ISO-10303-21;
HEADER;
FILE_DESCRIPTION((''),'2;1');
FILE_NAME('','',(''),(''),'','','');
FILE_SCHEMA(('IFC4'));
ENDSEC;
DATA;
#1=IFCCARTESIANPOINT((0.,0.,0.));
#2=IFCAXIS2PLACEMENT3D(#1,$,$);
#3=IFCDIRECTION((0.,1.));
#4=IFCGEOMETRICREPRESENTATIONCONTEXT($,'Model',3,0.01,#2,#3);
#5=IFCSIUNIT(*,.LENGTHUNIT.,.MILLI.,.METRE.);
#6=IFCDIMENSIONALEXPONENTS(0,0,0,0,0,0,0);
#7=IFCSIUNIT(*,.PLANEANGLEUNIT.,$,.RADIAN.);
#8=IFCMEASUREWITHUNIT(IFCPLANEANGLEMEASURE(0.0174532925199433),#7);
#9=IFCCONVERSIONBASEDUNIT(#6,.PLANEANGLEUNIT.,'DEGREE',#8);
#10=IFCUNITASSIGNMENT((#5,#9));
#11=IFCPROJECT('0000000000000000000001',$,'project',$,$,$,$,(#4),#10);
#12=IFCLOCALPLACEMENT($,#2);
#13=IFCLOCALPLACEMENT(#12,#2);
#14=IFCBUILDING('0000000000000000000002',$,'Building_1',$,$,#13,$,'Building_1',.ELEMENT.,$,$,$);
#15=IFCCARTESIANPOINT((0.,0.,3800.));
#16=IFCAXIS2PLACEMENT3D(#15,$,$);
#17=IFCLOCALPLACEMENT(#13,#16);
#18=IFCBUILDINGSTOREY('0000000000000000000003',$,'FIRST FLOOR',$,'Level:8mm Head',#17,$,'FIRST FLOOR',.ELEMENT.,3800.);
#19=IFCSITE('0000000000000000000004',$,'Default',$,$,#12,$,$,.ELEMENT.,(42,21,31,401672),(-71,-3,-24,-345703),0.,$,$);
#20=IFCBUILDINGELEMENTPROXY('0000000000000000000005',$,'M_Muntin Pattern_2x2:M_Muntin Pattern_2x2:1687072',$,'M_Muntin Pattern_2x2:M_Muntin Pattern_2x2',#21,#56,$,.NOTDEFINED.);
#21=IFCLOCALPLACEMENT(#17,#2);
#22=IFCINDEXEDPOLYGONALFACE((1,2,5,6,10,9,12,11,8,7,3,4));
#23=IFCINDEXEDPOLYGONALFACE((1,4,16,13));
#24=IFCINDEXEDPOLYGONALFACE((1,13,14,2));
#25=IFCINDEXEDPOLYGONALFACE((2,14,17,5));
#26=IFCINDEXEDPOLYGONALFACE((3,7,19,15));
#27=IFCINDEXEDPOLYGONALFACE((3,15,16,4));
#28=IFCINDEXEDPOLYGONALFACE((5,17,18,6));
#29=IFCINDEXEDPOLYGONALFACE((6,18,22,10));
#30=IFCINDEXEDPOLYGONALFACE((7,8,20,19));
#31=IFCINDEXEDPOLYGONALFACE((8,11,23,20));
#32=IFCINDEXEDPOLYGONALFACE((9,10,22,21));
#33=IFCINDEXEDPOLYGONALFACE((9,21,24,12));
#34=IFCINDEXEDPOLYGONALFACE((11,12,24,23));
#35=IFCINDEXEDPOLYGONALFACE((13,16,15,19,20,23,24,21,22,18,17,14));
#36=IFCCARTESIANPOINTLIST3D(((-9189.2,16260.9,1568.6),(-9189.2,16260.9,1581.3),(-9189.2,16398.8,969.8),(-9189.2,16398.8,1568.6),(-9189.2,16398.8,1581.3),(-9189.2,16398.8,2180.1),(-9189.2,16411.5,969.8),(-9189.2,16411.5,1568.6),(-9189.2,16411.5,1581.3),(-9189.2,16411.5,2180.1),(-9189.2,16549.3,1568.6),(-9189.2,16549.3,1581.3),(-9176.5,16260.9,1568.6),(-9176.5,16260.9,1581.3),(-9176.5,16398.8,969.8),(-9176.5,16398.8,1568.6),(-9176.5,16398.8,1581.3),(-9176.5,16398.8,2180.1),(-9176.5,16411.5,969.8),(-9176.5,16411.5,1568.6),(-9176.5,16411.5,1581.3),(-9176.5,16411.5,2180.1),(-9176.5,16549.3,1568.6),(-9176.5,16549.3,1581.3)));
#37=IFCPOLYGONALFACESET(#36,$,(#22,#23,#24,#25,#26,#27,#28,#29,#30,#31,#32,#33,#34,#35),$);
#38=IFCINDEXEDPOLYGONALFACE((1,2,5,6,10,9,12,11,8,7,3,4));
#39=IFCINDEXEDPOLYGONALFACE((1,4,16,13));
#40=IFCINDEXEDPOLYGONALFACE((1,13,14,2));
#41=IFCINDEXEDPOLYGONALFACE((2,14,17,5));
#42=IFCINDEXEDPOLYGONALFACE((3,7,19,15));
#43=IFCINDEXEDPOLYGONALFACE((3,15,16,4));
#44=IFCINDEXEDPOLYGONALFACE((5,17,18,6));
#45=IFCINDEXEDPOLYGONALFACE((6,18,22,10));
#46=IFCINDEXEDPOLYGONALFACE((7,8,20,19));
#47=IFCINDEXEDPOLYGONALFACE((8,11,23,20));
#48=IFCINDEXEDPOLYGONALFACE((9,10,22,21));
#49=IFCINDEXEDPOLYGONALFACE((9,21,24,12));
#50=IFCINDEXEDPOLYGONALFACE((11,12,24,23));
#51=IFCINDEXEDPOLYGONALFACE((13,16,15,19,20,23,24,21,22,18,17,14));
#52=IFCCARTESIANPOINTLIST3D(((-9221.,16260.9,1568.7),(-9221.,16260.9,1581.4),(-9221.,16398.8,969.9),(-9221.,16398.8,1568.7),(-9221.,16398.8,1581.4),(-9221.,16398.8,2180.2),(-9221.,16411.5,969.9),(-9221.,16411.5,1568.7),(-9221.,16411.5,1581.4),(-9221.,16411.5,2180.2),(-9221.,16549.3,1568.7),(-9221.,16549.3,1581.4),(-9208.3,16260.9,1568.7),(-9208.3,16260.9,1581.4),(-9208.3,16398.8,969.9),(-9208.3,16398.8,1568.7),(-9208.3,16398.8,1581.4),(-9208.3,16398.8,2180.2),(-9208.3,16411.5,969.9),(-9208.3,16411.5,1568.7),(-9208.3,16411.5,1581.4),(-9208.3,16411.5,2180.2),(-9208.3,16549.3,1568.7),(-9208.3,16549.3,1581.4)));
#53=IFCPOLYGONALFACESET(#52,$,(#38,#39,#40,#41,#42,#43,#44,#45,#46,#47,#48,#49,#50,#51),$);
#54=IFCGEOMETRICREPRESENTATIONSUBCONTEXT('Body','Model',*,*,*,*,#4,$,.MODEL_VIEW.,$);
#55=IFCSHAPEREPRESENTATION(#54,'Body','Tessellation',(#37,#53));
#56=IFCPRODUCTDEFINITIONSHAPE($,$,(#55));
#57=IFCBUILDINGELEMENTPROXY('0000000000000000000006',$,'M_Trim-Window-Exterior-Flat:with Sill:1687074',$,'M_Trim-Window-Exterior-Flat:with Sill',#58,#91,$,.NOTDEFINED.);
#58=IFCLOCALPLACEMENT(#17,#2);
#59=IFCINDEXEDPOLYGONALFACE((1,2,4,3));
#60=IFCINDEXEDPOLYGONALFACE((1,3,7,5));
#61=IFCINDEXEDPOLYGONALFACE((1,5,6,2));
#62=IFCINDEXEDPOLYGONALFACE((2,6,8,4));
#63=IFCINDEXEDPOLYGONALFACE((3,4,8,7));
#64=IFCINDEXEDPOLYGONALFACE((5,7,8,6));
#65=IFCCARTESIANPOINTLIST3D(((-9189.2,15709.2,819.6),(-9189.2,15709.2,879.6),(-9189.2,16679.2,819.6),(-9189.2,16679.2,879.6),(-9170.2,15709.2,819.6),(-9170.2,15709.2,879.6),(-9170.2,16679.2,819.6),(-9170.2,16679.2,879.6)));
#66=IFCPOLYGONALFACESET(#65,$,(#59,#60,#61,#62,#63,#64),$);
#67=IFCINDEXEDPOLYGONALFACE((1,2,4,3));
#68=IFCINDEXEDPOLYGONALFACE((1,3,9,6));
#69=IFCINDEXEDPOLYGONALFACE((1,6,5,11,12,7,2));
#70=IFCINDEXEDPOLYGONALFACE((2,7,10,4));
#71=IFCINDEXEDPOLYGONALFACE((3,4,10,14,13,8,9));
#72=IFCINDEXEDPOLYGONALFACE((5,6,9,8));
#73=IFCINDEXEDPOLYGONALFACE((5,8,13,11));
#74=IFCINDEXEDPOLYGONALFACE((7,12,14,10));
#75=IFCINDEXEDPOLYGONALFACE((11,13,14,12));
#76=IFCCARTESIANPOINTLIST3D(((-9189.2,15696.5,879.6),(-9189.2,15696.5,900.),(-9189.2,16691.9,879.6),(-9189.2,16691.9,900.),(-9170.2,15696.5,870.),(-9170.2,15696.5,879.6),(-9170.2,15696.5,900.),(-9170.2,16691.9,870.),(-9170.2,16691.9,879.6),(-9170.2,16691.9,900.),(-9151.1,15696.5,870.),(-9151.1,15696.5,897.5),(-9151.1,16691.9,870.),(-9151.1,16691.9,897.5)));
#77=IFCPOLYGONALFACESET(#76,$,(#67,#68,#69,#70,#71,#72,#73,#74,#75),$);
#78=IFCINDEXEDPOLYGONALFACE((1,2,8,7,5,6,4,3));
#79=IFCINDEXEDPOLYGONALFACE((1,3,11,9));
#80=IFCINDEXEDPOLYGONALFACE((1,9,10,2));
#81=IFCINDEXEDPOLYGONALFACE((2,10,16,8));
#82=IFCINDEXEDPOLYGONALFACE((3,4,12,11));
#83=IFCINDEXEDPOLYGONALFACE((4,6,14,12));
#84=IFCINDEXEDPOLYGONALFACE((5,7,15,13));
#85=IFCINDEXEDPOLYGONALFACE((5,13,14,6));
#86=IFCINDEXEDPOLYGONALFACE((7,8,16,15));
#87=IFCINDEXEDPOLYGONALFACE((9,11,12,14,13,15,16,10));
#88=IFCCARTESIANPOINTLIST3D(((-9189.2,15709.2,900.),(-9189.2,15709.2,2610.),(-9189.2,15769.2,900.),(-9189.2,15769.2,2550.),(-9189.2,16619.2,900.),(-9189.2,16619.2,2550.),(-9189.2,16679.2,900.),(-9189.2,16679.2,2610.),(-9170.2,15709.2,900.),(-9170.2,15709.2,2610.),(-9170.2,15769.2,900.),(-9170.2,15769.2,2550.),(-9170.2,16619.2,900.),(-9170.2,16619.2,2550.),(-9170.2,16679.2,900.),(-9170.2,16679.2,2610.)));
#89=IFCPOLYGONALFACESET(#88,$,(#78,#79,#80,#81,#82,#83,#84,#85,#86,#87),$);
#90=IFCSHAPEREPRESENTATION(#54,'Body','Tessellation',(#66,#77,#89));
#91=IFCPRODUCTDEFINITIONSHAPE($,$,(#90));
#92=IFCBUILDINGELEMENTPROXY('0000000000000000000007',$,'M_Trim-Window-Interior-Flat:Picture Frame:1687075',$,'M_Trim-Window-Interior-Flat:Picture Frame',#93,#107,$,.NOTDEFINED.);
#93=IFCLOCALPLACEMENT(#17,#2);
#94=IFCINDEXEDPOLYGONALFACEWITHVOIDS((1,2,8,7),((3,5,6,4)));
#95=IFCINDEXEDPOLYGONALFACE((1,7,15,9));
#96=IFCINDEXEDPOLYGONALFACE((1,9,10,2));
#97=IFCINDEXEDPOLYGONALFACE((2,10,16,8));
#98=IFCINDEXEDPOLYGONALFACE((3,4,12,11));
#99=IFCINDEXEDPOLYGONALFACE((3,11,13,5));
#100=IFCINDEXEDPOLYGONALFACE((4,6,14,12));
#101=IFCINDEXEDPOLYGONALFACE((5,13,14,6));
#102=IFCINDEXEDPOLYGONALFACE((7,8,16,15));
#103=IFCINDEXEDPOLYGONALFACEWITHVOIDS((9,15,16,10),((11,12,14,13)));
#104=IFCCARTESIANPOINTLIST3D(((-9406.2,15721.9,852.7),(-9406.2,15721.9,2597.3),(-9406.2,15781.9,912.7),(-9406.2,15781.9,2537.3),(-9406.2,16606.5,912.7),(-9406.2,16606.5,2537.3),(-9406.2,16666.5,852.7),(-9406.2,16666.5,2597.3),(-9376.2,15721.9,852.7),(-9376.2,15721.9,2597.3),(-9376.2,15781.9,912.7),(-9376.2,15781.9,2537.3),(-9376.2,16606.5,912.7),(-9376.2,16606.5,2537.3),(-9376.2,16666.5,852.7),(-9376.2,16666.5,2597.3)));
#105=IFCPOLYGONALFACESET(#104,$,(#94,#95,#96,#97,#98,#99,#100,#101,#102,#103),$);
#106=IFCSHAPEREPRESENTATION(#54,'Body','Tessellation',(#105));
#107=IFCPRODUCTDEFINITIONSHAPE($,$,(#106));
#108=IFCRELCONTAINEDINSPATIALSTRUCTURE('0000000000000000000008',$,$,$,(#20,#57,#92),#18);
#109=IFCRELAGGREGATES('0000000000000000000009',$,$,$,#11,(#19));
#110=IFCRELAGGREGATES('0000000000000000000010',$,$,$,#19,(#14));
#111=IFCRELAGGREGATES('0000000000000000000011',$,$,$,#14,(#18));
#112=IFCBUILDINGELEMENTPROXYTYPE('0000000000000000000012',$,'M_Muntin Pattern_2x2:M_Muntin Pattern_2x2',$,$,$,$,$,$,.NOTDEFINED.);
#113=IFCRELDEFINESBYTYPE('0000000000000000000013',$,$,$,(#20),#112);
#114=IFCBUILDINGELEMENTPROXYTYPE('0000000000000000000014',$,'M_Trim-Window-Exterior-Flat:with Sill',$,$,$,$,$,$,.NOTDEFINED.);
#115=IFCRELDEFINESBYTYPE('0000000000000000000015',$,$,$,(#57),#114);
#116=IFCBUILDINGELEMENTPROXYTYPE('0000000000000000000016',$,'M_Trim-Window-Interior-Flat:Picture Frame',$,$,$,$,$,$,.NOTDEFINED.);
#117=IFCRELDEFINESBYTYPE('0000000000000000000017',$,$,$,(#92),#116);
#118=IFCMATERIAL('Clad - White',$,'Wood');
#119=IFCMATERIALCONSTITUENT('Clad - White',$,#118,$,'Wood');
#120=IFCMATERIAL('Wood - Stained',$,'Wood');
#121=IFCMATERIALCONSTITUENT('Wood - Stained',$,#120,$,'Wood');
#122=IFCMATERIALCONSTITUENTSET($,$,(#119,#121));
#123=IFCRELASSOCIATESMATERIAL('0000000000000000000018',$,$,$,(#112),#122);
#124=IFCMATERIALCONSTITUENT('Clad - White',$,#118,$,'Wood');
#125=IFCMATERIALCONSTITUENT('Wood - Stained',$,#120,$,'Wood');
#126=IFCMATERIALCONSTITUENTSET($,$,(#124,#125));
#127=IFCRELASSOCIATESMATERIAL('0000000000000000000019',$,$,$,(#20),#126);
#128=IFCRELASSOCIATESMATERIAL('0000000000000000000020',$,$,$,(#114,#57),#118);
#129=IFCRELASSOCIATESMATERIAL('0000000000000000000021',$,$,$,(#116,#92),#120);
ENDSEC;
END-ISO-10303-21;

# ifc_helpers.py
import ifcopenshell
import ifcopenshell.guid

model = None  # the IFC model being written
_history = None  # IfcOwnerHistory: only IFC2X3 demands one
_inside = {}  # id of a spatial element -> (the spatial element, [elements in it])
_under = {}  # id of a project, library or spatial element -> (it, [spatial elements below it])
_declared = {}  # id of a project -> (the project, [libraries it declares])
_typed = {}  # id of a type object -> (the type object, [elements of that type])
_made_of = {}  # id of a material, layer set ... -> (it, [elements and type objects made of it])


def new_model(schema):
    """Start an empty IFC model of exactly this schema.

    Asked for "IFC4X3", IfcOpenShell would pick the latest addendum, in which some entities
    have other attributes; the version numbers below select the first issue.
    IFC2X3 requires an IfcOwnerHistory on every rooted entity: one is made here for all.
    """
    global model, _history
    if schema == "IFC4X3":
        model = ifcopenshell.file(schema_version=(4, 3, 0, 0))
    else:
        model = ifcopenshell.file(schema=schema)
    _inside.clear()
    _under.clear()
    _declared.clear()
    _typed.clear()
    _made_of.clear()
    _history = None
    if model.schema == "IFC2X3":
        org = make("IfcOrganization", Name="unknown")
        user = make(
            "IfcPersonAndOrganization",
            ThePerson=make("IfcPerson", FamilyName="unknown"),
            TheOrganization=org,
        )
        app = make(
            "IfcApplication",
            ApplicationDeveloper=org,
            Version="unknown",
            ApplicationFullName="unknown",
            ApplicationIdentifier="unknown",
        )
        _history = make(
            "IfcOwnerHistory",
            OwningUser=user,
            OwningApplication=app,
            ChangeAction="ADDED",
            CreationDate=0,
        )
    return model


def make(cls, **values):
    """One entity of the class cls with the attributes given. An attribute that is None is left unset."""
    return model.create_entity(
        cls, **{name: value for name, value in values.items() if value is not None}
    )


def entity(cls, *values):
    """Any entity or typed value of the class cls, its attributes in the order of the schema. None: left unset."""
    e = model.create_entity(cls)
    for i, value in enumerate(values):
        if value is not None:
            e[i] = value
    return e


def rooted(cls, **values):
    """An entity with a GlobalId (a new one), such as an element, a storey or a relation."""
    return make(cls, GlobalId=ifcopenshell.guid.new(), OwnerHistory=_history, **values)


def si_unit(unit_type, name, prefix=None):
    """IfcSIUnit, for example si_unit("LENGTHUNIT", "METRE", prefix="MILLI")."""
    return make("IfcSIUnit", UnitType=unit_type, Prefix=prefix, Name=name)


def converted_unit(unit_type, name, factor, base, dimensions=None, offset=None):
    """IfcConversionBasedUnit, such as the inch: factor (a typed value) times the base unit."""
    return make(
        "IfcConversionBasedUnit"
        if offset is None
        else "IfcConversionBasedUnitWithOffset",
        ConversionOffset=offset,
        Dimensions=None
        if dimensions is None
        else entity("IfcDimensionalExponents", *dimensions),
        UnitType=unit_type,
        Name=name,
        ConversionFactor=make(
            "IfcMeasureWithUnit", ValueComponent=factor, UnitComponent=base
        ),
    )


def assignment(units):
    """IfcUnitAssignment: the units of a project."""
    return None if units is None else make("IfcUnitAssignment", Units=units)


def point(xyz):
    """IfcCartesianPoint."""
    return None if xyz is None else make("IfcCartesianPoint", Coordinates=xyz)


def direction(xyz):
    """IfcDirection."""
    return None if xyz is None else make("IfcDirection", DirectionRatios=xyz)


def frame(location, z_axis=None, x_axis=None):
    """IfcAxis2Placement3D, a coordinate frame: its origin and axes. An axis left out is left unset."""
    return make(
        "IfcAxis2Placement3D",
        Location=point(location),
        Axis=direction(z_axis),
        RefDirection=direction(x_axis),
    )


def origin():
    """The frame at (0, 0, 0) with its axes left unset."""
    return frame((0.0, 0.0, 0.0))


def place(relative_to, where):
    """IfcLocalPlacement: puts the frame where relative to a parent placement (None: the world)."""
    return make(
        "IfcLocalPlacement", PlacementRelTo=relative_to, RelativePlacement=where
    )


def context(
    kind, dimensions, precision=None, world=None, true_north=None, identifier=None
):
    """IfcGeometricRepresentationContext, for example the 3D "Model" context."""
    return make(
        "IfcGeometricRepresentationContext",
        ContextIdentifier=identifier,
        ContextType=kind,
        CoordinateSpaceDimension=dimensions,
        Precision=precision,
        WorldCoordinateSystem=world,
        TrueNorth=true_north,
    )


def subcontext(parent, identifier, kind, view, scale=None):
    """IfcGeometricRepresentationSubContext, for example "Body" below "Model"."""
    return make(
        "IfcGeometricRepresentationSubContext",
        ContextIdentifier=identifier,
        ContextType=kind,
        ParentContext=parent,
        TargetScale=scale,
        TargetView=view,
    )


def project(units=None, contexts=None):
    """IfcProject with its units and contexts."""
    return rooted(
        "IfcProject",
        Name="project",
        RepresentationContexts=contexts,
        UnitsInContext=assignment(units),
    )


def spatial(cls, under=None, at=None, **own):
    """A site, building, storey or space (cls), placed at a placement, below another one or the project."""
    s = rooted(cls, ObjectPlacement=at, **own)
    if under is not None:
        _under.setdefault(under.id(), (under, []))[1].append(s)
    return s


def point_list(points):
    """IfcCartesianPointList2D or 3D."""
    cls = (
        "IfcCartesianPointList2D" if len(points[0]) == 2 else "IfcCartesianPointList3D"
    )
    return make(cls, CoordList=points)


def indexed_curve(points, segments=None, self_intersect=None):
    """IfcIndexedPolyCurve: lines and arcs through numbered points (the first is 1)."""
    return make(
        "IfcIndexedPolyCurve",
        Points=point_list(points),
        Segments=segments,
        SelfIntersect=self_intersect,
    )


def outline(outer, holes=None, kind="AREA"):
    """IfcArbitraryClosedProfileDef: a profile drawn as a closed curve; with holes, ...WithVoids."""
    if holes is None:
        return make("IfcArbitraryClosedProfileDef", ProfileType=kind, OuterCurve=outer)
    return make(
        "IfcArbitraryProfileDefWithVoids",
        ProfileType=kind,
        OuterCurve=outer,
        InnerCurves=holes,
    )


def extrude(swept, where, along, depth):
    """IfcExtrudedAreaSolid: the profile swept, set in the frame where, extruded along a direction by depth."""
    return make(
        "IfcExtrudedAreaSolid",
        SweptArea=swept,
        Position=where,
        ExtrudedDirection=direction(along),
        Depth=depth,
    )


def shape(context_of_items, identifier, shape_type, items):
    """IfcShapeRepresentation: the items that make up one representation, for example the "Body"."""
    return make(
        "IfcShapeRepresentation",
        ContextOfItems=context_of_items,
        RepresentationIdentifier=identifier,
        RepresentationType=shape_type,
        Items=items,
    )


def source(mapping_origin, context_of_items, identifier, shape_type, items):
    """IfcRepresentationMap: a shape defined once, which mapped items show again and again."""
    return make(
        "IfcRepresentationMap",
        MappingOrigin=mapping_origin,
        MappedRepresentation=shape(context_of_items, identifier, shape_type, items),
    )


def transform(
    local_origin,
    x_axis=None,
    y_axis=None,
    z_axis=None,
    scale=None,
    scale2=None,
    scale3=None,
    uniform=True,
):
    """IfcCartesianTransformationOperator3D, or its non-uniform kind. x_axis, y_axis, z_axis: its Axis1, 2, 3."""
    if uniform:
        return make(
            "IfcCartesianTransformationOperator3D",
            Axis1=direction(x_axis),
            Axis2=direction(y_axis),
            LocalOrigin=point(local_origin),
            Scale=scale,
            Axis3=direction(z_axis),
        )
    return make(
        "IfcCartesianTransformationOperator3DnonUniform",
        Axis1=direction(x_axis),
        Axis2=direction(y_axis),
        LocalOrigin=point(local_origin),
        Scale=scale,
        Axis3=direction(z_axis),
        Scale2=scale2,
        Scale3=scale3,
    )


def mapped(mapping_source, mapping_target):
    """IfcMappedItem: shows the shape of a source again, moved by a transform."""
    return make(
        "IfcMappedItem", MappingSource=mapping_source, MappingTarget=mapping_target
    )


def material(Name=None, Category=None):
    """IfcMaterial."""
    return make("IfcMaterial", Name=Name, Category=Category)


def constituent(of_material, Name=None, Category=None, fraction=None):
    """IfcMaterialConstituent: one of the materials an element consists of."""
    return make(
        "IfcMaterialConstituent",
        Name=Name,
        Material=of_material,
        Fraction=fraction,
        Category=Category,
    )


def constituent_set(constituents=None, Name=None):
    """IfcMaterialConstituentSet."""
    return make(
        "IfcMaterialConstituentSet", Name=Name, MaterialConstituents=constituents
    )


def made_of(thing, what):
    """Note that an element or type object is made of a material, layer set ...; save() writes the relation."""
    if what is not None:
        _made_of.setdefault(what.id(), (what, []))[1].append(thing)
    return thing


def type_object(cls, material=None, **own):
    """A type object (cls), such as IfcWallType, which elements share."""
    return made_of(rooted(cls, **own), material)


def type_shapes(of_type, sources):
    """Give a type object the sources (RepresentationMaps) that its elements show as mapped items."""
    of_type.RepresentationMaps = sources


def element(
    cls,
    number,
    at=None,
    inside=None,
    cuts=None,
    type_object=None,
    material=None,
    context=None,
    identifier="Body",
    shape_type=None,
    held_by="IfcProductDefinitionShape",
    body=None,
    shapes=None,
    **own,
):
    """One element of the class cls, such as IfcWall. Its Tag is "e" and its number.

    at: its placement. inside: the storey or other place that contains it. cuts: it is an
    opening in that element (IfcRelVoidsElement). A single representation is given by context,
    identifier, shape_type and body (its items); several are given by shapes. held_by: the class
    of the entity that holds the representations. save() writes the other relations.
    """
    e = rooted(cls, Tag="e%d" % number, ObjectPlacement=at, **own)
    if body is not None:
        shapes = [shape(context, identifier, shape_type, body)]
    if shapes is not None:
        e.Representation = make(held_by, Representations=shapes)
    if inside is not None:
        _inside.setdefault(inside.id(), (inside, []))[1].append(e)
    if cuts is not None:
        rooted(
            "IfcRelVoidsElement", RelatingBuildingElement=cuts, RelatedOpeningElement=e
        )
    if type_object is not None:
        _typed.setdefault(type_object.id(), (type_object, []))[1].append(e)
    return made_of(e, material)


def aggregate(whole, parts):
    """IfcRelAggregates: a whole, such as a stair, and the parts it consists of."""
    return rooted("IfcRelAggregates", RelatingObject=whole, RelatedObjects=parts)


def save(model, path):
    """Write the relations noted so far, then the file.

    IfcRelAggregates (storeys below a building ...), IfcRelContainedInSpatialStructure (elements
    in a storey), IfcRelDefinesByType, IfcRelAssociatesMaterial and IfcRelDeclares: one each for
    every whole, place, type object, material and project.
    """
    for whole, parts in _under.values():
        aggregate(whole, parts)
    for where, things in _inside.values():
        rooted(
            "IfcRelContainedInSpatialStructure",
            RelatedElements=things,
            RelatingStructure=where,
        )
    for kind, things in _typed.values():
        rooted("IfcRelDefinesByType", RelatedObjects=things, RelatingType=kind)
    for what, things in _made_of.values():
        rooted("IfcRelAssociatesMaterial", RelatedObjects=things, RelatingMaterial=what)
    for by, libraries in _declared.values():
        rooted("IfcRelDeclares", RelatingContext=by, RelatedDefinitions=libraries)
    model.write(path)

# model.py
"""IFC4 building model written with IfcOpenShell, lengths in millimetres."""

from ifc_helpers import new_model, entity, si_unit, converted_unit, direction, frame, origin, place, context, subcontext, project, spatial, indexed_curve, outline, extrude, source, transform, mapped, material, constituent, constituent_set, type_object, type_shapes, element, save


model = new_model("IFC4")

# Units and contexts
model_context = context("Model", 3, precision=0.01, world=origin(), true_north=direction((0.0, 1.0)))
body_context = subcontext(model_context, "Body", "Model", "MODEL_VIEW")
ifc_project = project(units=[si_unit("LENGTHUNIT", "METRE", prefix="MILLI"), converted_unit("PLANEANGLEUNIT", "DEGREE", entity("IfcPlaneAngleMeasure", 0.0174532925199433), si_unit("PLANEANGLEUNIT", "RADIAN"), dimensions=[0, 0, 0, 0, 0, 0, 0])], contexts=[model_context])

# Site, building, storey
site_placement = place(None, origin())
site = spatial("IfcSite", under=ifc_project, at=site_placement, Name="Default", CompositionType="ELEMENT", RefLatitude=(42, 21, 31, 401672), RefLongitude=(-71, -3, -24, -345703), RefElevation=0.0)
building_placement = place(site_placement, origin())
building = spatial("IfcBuilding", under=site, at=building_placement, Name="Building_1", LongName="Building_1", CompositionType="ELEMENT")
storey_placement = place(building_placement, frame((0.0, 0.0, 3800.0)))
storey = spatial("IfcBuildingStorey", under=building, at=storey_placement, Name="FIRST FLOOR", ObjectType="Level:8mm Head", LongName="FIRST FLOOR", CompositionType="ELEMENT", Elevation=3800.0)

# Shared definitions
ifc_material_1 = material(Name="Wood - Stained", Category="Wood")

# Building element proxies
ifc_material_2 = material(Name="Clad - White", Category="Wood")
ifc_constituent_1 = constituent(ifc_material_2, Name="Clad - White", Category="Wood")
ifc_constituent_2 = constituent(ifc_material_1, Name="Wood - Stained", Category="Wood")
ifc_constituent_set_1 = constituent_set(constituents=[ifc_constituent_1, ifc_constituent_2])
ifc_constituent_3 = constituent(ifc_material_2, Name="Clad - White", Category="Wood")
ifc_constituent_4 = constituent(ifc_material_1, Name="Wood - Stained", Category="Wood")
ifc_constituent_set_2 = constituent_set(constituents=[ifc_constituent_3, ifc_constituent_4])
building_element_proxy_type_1 = type_object("IfcBuildingElementProxyType", Name="M_Muntin Pattern_2x2:M_Muntin Pattern_2x2", PredefinedType="NOTDEFINED", material=ifc_constituent_set_2)
shared_shape_1 = source(origin(), body_context, "Body", "SweptSolid", [
    extrude(outline(indexed_curve([(6.4, -6.4), (605.1, -6.4), (605.1, 6.3), (6.4, 6.3), (6.4, 144.2), (-6.3, 144.2), (-6.3, 6.3), (-605.2, 6.3), (-605.2, -6.4), (-6.3, -6.4), (-6.3, -144.2), (6.4, -144.2), (6.4, -6.4)], self_intersect=False)), frame((0.0, 9.5, 605.1), z_axis=(0.0, 1.0, 0.0), x_axis=(0.0, 0.0, 1.0)), (0.0, 0.0, 1.0), 12.7),
    extrude(outline(indexed_curve([(6.4, -6.4), (605.2, -6.4), (605.2, 6.3), (6.4, 6.3), (6.4, 144.2), (-6.3, 144.2), (-6.3, 6.3), (-605.2, 6.3), (-605.2, -6.4), (-6.3, -6.4), (-6.3, -144.2), (6.4, -144.2), (6.4, -6.4)], self_intersect=False)), frame((0.0, -22.2, 605.2), z_axis=(0.0, 1.0, 0.0), x_axis=(0.0, 0.0, 1.0)), (0.0, 0.0, 1.0), 12.7),
])
type_shapes(building_element_proxy_type_1, [shared_shape_1])
proxy_1_placement = place(storey_placement, frame((-9198.7, 16405.1, 969.9), z_axis=(0.0, 0.0, 1.0), x_axis=(0.0, -1.0, 0.0)))
element("IfcBuildingElementProxy", 1, at=proxy_1_placement, inside=storey, type_object=building_element_proxy_type_1, material=ifc_constituent_set_1, Name="M_Muntin Pattern_2x2:M_Muntin Pattern_2x2:1687072", ObjectType="M_Muntin Pattern_2x2:M_Muntin Pattern_2x2", PredefinedType="NOTDEFINED", context=body_context, shape_type="MappedRepresentation", body=[
    mapped(shared_shape_1, transform((0.0, 0.0, 0.0), scale=1.0)),
])
building_element_proxy_type_2 = type_object("IfcBuildingElementProxyType", Name="M_Trim-Window-Exterior-Flat:with Sill", PredefinedType="NOTDEFINED", material=ifc_material_2)
shared_shape_2 = source(origin(), body_context, "Body", "SweptSolid", [
    extrude(outline(indexed_curve([(-485.0, -30.0), (485.0, -30.0), (485.0, 30.0), (-485.0, 30.0), (-485.0, -30.0)], self_intersect=False)), frame((0.0, -1700.4, 0.0), z_axis=(0.0, 0.0, 1.0), x_axis=(-1.0, 0.0, 0.0)), (0.0, 0.0, 1.0), 19.1),
    extrude(outline(indexed_curve([(-19.0, -15.2), (0.0, -15.2), (0.0, -5.7), (19.0, -5.7), (19.0, 14.8), (0.0, 14.8), (-19.0, 12.3), (-19.0, -15.2)], self_intersect=False)), frame((-497.7, -1664.8, 19.0), z_axis=(1.0, 0.0, 0.0), x_axis=(0.0, 0.0, -1.0)), (0.0, 0.0, 1.0), 995.4),
    extrude(outline(indexed_curve([(-870.0, -485.0), (840.0, -485.0), (840.0, -425.0), (-810.0, -425.0), (-810.0, 425.0), (840.0, 425.0), (840.0, 485.0), (-870.0, 485.0), (-870.0, -485.0)], self_intersect=False)), frame((0.0, -810.0, 0.0), z_axis=(0.0, 0.0, 1.0), x_axis=(0.0, -1.0, 0.0)), (0.0, 0.0, 1.0), 19.1),
])
type_shapes(building_element_proxy_type_2, [shared_shape_2])
proxy_2_placement = place(storey_placement, frame((-9189.2, 16194.2, 2550.0), z_axis=(1.0, 0.0, 0.0), x_axis=(0.0, 1.0, 0.0)))
element("IfcBuildingElementProxy", 2, at=proxy_2_placement, inside=storey, type_object=building_element_proxy_type_2, material=ifc_material_2, Name="M_Trim-Window-Exterior-Flat:with Sill:1687074", ObjectType="M_Trim-Window-Exterior-Flat:with Sill", PredefinedType="NOTDEFINED", context=body_context, shape_type="MappedRepresentation", body=[
    mapped(shared_shape_2, transform((0.0, 0.0, 0.0), scale=1.0)),
])
building_element_proxy_type_3 = type_object("IfcBuildingElementProxyType", Name="M_Trim-Window-Interior-Flat:Picture Frame", PredefinedType="NOTDEFINED", material=ifc_material_1)
shared_shape_3 = source(origin(), body_context, "Body", "SweptSolid", [
    extrude(outline(indexed_curve([(-472.3, -872.3), (472.3, -872.3), (472.3, 872.3), (-472.3, 872.3), (-472.3, -872.3)], self_intersect=False), holes=[indexed_curve([(-412.3, -812.3), (-412.3, 812.3), (412.3, 812.3), (412.3, -812.3), (-412.3, -812.3)], self_intersect=False)]), frame((0.0, -825.0, 0.0), z_axis=(0.0, 0.0, 1.0), x_axis=(-1.0, 0.0, 0.0)), (0.0, 0.0, 1.0), 30.0),
])
type_shapes(building_element_proxy_type_3, [shared_shape_3])
proxy_3_placement = place(storey_placement, frame((-9376.2, 16194.2, 2550.0), z_axis=(-1.0, 0.0, 0.0), x_axis=(0.0, -1.0, 0.0)))
element("IfcBuildingElementProxy", 3, at=proxy_3_placement, inside=storey, type_object=building_element_proxy_type_3, material=ifc_material_1, Name="M_Trim-Window-Interior-Flat:Picture Frame:1687075", ObjectType="M_Trim-Window-Interior-Flat:Picture Frame", PredefinedType="NOTDEFINED", context=body_context, shape_type="MappedRepresentation", body=[
    mapped(shared_shape_3, transform((0.0, 0.0, 0.0), scale=1.0)),
])

save(model, "model.ifc")
